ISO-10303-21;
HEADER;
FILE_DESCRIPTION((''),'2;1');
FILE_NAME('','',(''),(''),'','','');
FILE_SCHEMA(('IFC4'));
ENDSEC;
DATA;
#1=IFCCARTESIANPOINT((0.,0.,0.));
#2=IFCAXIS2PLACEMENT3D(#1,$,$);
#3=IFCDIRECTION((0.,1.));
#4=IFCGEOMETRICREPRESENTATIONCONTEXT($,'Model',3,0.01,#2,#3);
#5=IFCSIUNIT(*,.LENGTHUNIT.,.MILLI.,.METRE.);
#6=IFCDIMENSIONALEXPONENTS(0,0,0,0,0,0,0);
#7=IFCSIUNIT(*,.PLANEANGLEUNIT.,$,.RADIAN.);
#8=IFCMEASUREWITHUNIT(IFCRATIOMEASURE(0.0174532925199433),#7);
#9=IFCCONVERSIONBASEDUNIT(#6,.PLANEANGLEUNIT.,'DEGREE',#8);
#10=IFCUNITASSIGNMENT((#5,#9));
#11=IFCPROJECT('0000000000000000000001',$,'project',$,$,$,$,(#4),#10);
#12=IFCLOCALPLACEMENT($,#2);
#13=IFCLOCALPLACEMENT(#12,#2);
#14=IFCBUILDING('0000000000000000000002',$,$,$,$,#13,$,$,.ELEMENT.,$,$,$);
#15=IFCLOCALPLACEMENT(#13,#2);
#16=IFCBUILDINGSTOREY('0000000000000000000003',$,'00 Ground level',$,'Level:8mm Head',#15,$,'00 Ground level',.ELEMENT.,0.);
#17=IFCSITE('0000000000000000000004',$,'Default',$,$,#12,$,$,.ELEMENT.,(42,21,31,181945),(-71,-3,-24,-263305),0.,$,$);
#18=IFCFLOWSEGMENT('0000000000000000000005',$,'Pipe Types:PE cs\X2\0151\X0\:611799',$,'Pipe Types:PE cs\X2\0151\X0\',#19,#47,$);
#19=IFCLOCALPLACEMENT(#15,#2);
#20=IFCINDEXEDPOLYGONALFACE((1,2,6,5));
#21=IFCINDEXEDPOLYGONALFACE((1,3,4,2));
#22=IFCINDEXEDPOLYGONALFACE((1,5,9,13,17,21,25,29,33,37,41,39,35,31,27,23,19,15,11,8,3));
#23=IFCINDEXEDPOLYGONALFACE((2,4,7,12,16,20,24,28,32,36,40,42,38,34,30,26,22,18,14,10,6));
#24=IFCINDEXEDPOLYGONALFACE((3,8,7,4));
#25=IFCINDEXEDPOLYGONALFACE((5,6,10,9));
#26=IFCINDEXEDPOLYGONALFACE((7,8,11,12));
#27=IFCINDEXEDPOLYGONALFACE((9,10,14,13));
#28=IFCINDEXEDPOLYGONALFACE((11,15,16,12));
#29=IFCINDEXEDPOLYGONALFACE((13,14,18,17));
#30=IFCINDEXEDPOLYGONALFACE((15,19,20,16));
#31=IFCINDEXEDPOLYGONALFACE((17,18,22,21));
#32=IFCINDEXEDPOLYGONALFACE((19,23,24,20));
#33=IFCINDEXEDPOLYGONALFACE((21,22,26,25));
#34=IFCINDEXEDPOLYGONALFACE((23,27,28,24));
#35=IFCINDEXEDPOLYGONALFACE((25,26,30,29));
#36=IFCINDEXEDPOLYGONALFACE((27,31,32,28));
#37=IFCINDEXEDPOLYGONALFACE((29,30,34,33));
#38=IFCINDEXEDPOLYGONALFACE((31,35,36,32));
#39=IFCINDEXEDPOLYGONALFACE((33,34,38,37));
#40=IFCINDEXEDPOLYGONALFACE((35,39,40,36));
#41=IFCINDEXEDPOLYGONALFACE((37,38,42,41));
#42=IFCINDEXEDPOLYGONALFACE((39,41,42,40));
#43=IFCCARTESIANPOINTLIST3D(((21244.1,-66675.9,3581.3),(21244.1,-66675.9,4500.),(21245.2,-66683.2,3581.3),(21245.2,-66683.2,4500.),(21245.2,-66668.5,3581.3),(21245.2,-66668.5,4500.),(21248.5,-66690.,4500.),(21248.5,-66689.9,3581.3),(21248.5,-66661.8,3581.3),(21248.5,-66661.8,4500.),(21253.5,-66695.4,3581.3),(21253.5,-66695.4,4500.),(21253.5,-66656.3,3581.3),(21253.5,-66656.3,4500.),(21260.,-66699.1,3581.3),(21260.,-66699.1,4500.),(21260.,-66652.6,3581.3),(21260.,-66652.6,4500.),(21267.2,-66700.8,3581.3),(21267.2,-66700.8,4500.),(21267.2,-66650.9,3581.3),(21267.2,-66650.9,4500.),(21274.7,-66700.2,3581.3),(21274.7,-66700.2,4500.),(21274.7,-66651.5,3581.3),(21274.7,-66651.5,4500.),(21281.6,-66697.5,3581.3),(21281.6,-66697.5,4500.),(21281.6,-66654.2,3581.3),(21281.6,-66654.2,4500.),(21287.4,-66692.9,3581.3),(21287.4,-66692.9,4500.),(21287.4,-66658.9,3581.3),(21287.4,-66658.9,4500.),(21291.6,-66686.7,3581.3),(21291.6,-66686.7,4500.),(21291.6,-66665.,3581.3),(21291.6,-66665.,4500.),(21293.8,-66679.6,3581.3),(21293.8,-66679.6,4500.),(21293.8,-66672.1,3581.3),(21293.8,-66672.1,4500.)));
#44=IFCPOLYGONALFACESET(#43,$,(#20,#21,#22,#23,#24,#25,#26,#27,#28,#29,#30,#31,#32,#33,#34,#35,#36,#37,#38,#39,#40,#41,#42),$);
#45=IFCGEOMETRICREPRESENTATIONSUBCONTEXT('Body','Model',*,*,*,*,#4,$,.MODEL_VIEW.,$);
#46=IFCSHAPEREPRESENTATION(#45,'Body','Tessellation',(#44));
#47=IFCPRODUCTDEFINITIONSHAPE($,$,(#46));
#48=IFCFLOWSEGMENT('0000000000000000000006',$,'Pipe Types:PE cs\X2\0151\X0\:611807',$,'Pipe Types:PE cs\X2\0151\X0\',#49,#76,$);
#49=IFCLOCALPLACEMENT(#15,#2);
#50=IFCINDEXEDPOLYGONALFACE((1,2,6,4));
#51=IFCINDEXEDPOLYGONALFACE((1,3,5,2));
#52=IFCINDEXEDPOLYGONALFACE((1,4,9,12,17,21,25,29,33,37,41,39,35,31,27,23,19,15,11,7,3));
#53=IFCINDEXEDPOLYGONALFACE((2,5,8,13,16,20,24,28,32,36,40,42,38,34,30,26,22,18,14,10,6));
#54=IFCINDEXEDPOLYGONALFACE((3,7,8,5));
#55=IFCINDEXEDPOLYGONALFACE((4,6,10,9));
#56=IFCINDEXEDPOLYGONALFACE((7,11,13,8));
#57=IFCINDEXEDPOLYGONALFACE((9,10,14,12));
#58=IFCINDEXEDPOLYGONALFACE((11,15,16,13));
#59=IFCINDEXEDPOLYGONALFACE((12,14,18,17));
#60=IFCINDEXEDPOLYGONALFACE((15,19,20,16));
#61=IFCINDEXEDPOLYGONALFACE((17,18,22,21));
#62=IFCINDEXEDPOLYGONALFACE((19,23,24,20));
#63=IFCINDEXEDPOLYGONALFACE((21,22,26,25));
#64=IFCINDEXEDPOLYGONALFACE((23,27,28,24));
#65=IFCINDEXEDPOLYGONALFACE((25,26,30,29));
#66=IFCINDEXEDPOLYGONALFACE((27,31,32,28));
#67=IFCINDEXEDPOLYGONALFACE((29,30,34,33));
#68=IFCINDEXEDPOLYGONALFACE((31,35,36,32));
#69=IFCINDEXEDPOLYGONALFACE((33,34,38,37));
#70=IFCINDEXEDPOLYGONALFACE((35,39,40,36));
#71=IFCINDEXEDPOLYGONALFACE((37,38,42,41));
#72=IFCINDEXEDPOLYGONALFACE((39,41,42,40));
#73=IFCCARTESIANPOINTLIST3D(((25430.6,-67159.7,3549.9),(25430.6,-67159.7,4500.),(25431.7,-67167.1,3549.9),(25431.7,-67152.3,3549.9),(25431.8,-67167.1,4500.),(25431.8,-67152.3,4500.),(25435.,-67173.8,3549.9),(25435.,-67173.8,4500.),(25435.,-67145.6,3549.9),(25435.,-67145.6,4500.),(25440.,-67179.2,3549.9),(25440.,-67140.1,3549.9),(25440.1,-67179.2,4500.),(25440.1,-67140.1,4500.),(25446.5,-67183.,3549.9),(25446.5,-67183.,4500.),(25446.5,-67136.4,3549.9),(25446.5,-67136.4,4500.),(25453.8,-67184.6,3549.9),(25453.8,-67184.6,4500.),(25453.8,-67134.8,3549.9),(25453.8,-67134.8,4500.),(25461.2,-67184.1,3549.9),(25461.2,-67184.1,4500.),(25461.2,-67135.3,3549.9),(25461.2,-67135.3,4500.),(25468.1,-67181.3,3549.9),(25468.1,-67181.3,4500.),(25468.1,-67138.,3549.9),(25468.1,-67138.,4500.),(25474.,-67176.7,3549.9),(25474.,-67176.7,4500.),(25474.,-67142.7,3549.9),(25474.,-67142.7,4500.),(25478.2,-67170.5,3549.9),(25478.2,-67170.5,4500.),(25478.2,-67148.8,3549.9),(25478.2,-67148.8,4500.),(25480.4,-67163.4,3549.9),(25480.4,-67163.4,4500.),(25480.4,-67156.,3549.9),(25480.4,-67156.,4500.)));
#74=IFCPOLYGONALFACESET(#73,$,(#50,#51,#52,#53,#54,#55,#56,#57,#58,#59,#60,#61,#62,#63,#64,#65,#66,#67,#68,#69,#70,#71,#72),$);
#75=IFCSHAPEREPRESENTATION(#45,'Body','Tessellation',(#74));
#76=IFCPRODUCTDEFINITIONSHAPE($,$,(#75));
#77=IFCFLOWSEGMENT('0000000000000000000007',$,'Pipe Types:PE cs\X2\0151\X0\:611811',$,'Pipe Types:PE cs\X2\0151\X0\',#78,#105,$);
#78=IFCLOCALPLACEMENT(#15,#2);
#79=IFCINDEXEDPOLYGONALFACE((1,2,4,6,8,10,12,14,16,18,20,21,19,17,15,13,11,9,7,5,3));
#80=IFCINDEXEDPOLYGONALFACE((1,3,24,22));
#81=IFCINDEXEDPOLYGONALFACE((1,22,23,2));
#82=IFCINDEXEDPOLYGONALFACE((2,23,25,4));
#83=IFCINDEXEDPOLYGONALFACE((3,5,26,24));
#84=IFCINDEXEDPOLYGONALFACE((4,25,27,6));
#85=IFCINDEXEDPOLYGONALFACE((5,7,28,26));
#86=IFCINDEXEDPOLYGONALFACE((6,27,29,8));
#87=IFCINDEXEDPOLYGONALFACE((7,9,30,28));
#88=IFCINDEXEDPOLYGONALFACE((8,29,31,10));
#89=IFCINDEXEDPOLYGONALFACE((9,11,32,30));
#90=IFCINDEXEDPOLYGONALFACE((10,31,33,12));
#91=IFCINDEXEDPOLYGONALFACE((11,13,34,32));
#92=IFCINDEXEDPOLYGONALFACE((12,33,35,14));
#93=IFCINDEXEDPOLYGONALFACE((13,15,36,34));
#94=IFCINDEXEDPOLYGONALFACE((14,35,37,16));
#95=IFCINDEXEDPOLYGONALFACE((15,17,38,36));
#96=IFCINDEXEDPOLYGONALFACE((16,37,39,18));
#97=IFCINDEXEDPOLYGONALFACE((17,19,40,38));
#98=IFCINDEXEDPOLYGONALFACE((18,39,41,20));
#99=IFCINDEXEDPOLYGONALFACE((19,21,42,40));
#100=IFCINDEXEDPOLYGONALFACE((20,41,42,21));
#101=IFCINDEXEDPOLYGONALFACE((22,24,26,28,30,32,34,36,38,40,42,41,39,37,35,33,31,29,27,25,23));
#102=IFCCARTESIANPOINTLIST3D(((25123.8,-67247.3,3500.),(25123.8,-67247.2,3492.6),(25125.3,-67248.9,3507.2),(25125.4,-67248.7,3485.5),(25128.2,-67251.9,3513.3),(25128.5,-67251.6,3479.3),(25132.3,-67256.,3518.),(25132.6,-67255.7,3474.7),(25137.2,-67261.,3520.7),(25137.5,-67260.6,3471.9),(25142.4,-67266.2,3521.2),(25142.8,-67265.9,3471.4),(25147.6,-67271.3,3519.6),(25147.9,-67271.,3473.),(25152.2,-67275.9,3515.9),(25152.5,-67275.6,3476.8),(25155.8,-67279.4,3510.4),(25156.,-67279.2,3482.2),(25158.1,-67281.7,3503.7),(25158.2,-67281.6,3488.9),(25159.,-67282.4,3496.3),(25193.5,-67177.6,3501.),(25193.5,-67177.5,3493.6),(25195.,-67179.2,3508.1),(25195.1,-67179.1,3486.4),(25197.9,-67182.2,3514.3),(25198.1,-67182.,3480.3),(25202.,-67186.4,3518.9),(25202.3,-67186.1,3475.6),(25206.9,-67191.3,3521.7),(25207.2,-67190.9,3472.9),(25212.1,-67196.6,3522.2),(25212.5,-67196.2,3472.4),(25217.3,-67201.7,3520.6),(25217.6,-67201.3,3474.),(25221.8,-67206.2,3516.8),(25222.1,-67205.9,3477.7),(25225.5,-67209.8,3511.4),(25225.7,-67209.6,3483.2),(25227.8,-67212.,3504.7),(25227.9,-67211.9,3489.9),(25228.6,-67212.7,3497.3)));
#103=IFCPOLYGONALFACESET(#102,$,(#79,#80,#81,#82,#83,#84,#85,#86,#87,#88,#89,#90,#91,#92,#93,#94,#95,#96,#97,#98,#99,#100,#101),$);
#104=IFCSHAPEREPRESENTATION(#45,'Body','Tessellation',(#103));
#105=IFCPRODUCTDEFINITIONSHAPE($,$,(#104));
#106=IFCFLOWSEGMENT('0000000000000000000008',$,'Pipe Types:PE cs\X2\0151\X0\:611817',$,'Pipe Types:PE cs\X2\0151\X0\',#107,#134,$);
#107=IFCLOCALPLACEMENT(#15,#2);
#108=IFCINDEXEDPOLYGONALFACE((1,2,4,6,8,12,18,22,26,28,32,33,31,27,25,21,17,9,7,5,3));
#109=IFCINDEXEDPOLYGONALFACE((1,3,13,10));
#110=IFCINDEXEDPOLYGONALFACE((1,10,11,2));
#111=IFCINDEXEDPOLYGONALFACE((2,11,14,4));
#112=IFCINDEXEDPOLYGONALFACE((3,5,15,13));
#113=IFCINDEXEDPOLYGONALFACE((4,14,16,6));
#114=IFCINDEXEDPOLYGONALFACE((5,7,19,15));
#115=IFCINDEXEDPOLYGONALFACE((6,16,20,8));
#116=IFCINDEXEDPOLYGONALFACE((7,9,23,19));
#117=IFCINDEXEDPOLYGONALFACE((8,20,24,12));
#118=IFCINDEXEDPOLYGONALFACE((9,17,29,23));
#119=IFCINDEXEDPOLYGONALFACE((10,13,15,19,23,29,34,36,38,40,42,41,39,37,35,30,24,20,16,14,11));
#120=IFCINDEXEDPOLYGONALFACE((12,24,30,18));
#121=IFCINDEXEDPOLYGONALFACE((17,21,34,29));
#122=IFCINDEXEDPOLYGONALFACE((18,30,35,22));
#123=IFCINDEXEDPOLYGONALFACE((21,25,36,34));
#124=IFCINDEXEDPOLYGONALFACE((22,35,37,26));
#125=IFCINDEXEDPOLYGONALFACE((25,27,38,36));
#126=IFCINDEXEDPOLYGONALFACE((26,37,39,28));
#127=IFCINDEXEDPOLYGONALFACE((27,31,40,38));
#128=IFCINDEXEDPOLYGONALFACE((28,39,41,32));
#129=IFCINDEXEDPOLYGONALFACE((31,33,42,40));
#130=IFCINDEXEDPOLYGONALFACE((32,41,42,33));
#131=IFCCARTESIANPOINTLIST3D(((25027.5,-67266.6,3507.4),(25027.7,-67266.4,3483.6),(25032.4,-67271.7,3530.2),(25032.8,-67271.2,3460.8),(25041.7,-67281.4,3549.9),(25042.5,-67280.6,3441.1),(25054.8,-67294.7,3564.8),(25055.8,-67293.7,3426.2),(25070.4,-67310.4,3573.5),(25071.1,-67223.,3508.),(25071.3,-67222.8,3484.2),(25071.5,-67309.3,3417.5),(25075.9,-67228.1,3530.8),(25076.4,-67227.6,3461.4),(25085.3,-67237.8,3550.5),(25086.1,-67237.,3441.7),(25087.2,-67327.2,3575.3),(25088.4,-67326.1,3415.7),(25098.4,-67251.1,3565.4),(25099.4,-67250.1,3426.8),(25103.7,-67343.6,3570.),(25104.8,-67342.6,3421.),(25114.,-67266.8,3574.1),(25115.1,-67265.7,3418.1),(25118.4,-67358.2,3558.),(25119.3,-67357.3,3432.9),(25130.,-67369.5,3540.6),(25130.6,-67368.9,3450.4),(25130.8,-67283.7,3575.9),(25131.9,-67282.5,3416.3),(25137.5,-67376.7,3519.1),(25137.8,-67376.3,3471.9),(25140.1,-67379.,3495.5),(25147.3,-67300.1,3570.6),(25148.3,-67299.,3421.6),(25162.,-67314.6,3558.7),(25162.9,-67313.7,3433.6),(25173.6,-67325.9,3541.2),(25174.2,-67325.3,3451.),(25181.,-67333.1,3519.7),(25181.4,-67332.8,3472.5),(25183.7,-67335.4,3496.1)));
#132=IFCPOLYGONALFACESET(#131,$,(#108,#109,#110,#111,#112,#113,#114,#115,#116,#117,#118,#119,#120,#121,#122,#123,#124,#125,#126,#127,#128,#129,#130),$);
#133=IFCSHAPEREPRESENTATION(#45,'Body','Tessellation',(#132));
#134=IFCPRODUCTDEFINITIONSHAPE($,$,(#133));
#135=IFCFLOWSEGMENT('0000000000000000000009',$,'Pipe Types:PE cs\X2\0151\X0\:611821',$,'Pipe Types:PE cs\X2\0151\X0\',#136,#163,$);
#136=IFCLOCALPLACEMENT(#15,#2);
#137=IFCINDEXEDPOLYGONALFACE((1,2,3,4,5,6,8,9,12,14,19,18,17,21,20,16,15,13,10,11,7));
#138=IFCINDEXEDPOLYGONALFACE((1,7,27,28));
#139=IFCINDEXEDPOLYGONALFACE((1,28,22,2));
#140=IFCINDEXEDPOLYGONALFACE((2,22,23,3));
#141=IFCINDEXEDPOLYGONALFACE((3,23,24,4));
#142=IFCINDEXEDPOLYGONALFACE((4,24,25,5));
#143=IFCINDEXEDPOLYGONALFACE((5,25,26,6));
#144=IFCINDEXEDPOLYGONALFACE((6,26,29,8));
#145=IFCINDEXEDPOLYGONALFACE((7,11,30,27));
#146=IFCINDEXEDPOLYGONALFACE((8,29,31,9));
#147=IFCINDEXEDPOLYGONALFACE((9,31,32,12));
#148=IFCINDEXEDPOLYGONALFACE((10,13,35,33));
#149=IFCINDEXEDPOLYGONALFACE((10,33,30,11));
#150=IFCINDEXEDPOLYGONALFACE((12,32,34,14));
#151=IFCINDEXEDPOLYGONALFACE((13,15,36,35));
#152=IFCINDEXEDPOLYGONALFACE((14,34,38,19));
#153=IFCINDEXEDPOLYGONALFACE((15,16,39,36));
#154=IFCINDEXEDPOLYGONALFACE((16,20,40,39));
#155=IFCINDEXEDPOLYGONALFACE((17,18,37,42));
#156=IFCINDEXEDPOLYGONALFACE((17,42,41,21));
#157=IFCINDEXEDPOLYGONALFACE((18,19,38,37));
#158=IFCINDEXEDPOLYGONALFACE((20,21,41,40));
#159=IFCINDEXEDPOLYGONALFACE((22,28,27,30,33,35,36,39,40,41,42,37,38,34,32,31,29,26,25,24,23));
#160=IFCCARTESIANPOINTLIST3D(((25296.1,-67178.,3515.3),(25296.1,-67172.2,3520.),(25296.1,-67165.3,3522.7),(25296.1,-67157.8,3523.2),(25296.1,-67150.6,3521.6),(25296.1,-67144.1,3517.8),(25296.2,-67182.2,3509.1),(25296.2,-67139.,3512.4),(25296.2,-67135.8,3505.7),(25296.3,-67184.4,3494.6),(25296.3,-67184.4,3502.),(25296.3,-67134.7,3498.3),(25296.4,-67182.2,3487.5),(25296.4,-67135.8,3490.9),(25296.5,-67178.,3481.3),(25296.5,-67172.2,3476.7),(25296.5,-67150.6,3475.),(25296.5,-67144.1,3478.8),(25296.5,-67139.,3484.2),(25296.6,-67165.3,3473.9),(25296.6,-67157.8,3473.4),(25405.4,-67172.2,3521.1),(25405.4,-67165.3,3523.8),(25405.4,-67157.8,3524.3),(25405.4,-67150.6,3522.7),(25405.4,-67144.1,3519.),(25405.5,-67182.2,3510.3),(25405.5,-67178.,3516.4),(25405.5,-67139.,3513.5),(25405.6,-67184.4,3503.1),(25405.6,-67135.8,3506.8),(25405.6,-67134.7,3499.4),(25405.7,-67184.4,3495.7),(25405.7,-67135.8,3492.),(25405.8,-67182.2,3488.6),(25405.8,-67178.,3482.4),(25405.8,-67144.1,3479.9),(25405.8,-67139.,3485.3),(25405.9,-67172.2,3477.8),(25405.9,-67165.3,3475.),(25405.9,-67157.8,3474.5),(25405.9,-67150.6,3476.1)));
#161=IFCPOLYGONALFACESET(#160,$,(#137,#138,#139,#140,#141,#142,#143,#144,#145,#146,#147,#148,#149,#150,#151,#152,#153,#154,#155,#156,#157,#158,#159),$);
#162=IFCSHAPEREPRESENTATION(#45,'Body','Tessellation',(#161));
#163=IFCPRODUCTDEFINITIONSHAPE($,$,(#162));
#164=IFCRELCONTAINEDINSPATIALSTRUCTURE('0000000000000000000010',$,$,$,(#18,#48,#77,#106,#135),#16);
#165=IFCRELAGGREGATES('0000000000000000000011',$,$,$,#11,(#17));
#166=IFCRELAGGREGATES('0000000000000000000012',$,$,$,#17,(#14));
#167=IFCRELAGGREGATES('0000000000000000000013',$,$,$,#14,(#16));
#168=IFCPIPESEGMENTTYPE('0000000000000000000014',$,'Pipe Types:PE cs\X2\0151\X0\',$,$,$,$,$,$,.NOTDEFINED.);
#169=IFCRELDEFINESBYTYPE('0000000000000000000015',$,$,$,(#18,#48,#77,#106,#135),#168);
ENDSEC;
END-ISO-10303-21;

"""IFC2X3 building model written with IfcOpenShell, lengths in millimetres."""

from ifc_helpers import new_model, entity, si_unit, converted_unit, direction, frame, origin, origin_2d_with_axis, place, context, subcontext, project, spatial, circle, extrude, type_object, element, save


model = new_model("IFC2X3")

# Units and contexts
model_context = context("Model", 3, precision=0.01, world=origin(), true_north=direction((0.0, 1.0)))
body_context = subcontext(model_context, "Body", "Model", "MODEL_VIEW")
ifc_project = project(units=[si_unit("LENGTHUNIT", "METRE", prefix="MILLI"), converted_unit("PLANEANGLEUNIT", "DEGREE", entity("IfcRatioMeasure", 0.0174532925199433), si_unit("PLANEANGLEUNIT", "RADIAN"), dimensions=[0, 0, 0, 0, 0, 0, 0])], contexts=[model_context])

# Site, building, storey
site_placement = place(None, origin())
site = spatial("IfcSite", under=ifc_project, at=site_placement, Name="Default", CompositionType="ELEMENT", RefLatitude=(42, 21, 31, 181945), RefLongitude=(-71, -3, -24, -263305), RefElevation=0.0)
building_placement = place(site_placement, origin())
building = spatial("IfcBuilding", under=site, at=building_placement, CompositionType="ELEMENT")
storey_placement = place(building_placement, origin())
storey = spatial("IfcBuildingStorey", under=building, at=storey_placement, Name="00 Ground level", ObjectType="Level:8mm Head", LongName="00 Ground level", CompositionType="ELEMENT", Elevation=0.0)

# Flow segments
pipe_segment_type = type_object("IfcPipeSegmentType", Name="Pipe Types:PE cső", PredefinedType="NOTDEFINED")
flow_segment_1_placement = place(storey_placement, frame((21242.5, -66702.5, 3581.3)))
element("IfcFlowSegment", 1, at=flow_segment_1_placement, inside=storey, type_object=pipe_segment_type, Name="Pipe Types:PE cső:611799", ObjectType="Pipe Types:PE cső", context=body_context, shape_type="SweptSolid", body=[
    extrude(circle(Radius=25.0, at=origin_2d_with_axis()), frame((26.6, 26.6, 0.0), z_axis=(0.0, -0.000009, 1.0), x_axis=(-1.0, 0.0, 0.0)), (0.0, 0.0, 1.0), 918.7),
])
flow_segment_2_placement = place(storey_placement, frame((25429.0, -67186.3, 3549.9)))
element("IfcFlowSegment", 2, at=flow_segment_2_placement, inside=storey, type_object=pipe_segment_type, Name="Pipe Types:PE cső:611807", ObjectType="Pipe Types:PE cső", context=body_context, shape_type="SweptSolid", body=[
    extrude(circle(Radius=25.0, at=origin_2d_with_axis()), frame((26.6, 26.6, 0.0), z_axis=(0.000007, 0.000001, 1.0), x_axis=(-1.0, 0.0, 0.000007)), (0.0, 0.0, 1.0), 950.1),
])
flow_segment_3_placement = place(storey_placement, frame((25122.0, -67284.0, 3469.7)))
element("IfcFlowSegment", 3, at=flow_segment_3_placement, inside=storey, type_object=pipe_segment_type, Name="Pipe Types:PE cső:611811", ObjectType="Pipe Types:PE cső", context=body_context, shape_type="SweptSolid", body=[
    extrude(circle(Radius=25.0, at=origin_2d_with_axis()), frame((19.3, 19.3, 26.6), z_axis=(0.707072, 0.707071, 0.009982), x_axis=(0.707107, -0.707107, 0.0)), (0.0, 0.0, 1.0), 98.5),
])
flow_segment_4_placement = place(storey_placement, frame((25025.4, -67380.6, 3413.9)))
element("IfcFlowSegment", 4, at=flow_segment_4_placement, inside=storey, type_object=pipe_segment_type, Name="Pipe Types:PE cső:611817", ObjectType="Pipe Types:PE cső", context=body_context, shape_type="SweptSolid", body=[
    extrude(circle(Radius=80.0, at=origin_2d_with_axis()), frame((58.2, 58.2, 81.6), z_axis=(0.707071, 0.707071, 0.010046), x_axis=(0.707107, -0.707107, 0.0)), (0.0, 0.0, 1.0), 61.6),
])
flow_segment_5_placement = place(storey_placement, frame((25294.5, -67186.3, 3471.7)))
element("IfcFlowSegment", 5, at=flow_segment_5_placement, inside=storey, type_object=pipe_segment_type, Name="Pipe Types:PE cső:611821", ObjectType="Pipe Types:PE cső", context=body_context, shape_type="SweptSolid", body=[
    extrude(circle(Radius=25.0, at=origin_2d_with_axis()), frame((1.9, 26.6, 26.6), z_axis=(0.999948, 0.000032, 0.010203), x_axis=(-0.000032, 1.0, 0.0)), (0.0, 0.0, 1.0), 109.3),
])

save(model, "model.ifc")
